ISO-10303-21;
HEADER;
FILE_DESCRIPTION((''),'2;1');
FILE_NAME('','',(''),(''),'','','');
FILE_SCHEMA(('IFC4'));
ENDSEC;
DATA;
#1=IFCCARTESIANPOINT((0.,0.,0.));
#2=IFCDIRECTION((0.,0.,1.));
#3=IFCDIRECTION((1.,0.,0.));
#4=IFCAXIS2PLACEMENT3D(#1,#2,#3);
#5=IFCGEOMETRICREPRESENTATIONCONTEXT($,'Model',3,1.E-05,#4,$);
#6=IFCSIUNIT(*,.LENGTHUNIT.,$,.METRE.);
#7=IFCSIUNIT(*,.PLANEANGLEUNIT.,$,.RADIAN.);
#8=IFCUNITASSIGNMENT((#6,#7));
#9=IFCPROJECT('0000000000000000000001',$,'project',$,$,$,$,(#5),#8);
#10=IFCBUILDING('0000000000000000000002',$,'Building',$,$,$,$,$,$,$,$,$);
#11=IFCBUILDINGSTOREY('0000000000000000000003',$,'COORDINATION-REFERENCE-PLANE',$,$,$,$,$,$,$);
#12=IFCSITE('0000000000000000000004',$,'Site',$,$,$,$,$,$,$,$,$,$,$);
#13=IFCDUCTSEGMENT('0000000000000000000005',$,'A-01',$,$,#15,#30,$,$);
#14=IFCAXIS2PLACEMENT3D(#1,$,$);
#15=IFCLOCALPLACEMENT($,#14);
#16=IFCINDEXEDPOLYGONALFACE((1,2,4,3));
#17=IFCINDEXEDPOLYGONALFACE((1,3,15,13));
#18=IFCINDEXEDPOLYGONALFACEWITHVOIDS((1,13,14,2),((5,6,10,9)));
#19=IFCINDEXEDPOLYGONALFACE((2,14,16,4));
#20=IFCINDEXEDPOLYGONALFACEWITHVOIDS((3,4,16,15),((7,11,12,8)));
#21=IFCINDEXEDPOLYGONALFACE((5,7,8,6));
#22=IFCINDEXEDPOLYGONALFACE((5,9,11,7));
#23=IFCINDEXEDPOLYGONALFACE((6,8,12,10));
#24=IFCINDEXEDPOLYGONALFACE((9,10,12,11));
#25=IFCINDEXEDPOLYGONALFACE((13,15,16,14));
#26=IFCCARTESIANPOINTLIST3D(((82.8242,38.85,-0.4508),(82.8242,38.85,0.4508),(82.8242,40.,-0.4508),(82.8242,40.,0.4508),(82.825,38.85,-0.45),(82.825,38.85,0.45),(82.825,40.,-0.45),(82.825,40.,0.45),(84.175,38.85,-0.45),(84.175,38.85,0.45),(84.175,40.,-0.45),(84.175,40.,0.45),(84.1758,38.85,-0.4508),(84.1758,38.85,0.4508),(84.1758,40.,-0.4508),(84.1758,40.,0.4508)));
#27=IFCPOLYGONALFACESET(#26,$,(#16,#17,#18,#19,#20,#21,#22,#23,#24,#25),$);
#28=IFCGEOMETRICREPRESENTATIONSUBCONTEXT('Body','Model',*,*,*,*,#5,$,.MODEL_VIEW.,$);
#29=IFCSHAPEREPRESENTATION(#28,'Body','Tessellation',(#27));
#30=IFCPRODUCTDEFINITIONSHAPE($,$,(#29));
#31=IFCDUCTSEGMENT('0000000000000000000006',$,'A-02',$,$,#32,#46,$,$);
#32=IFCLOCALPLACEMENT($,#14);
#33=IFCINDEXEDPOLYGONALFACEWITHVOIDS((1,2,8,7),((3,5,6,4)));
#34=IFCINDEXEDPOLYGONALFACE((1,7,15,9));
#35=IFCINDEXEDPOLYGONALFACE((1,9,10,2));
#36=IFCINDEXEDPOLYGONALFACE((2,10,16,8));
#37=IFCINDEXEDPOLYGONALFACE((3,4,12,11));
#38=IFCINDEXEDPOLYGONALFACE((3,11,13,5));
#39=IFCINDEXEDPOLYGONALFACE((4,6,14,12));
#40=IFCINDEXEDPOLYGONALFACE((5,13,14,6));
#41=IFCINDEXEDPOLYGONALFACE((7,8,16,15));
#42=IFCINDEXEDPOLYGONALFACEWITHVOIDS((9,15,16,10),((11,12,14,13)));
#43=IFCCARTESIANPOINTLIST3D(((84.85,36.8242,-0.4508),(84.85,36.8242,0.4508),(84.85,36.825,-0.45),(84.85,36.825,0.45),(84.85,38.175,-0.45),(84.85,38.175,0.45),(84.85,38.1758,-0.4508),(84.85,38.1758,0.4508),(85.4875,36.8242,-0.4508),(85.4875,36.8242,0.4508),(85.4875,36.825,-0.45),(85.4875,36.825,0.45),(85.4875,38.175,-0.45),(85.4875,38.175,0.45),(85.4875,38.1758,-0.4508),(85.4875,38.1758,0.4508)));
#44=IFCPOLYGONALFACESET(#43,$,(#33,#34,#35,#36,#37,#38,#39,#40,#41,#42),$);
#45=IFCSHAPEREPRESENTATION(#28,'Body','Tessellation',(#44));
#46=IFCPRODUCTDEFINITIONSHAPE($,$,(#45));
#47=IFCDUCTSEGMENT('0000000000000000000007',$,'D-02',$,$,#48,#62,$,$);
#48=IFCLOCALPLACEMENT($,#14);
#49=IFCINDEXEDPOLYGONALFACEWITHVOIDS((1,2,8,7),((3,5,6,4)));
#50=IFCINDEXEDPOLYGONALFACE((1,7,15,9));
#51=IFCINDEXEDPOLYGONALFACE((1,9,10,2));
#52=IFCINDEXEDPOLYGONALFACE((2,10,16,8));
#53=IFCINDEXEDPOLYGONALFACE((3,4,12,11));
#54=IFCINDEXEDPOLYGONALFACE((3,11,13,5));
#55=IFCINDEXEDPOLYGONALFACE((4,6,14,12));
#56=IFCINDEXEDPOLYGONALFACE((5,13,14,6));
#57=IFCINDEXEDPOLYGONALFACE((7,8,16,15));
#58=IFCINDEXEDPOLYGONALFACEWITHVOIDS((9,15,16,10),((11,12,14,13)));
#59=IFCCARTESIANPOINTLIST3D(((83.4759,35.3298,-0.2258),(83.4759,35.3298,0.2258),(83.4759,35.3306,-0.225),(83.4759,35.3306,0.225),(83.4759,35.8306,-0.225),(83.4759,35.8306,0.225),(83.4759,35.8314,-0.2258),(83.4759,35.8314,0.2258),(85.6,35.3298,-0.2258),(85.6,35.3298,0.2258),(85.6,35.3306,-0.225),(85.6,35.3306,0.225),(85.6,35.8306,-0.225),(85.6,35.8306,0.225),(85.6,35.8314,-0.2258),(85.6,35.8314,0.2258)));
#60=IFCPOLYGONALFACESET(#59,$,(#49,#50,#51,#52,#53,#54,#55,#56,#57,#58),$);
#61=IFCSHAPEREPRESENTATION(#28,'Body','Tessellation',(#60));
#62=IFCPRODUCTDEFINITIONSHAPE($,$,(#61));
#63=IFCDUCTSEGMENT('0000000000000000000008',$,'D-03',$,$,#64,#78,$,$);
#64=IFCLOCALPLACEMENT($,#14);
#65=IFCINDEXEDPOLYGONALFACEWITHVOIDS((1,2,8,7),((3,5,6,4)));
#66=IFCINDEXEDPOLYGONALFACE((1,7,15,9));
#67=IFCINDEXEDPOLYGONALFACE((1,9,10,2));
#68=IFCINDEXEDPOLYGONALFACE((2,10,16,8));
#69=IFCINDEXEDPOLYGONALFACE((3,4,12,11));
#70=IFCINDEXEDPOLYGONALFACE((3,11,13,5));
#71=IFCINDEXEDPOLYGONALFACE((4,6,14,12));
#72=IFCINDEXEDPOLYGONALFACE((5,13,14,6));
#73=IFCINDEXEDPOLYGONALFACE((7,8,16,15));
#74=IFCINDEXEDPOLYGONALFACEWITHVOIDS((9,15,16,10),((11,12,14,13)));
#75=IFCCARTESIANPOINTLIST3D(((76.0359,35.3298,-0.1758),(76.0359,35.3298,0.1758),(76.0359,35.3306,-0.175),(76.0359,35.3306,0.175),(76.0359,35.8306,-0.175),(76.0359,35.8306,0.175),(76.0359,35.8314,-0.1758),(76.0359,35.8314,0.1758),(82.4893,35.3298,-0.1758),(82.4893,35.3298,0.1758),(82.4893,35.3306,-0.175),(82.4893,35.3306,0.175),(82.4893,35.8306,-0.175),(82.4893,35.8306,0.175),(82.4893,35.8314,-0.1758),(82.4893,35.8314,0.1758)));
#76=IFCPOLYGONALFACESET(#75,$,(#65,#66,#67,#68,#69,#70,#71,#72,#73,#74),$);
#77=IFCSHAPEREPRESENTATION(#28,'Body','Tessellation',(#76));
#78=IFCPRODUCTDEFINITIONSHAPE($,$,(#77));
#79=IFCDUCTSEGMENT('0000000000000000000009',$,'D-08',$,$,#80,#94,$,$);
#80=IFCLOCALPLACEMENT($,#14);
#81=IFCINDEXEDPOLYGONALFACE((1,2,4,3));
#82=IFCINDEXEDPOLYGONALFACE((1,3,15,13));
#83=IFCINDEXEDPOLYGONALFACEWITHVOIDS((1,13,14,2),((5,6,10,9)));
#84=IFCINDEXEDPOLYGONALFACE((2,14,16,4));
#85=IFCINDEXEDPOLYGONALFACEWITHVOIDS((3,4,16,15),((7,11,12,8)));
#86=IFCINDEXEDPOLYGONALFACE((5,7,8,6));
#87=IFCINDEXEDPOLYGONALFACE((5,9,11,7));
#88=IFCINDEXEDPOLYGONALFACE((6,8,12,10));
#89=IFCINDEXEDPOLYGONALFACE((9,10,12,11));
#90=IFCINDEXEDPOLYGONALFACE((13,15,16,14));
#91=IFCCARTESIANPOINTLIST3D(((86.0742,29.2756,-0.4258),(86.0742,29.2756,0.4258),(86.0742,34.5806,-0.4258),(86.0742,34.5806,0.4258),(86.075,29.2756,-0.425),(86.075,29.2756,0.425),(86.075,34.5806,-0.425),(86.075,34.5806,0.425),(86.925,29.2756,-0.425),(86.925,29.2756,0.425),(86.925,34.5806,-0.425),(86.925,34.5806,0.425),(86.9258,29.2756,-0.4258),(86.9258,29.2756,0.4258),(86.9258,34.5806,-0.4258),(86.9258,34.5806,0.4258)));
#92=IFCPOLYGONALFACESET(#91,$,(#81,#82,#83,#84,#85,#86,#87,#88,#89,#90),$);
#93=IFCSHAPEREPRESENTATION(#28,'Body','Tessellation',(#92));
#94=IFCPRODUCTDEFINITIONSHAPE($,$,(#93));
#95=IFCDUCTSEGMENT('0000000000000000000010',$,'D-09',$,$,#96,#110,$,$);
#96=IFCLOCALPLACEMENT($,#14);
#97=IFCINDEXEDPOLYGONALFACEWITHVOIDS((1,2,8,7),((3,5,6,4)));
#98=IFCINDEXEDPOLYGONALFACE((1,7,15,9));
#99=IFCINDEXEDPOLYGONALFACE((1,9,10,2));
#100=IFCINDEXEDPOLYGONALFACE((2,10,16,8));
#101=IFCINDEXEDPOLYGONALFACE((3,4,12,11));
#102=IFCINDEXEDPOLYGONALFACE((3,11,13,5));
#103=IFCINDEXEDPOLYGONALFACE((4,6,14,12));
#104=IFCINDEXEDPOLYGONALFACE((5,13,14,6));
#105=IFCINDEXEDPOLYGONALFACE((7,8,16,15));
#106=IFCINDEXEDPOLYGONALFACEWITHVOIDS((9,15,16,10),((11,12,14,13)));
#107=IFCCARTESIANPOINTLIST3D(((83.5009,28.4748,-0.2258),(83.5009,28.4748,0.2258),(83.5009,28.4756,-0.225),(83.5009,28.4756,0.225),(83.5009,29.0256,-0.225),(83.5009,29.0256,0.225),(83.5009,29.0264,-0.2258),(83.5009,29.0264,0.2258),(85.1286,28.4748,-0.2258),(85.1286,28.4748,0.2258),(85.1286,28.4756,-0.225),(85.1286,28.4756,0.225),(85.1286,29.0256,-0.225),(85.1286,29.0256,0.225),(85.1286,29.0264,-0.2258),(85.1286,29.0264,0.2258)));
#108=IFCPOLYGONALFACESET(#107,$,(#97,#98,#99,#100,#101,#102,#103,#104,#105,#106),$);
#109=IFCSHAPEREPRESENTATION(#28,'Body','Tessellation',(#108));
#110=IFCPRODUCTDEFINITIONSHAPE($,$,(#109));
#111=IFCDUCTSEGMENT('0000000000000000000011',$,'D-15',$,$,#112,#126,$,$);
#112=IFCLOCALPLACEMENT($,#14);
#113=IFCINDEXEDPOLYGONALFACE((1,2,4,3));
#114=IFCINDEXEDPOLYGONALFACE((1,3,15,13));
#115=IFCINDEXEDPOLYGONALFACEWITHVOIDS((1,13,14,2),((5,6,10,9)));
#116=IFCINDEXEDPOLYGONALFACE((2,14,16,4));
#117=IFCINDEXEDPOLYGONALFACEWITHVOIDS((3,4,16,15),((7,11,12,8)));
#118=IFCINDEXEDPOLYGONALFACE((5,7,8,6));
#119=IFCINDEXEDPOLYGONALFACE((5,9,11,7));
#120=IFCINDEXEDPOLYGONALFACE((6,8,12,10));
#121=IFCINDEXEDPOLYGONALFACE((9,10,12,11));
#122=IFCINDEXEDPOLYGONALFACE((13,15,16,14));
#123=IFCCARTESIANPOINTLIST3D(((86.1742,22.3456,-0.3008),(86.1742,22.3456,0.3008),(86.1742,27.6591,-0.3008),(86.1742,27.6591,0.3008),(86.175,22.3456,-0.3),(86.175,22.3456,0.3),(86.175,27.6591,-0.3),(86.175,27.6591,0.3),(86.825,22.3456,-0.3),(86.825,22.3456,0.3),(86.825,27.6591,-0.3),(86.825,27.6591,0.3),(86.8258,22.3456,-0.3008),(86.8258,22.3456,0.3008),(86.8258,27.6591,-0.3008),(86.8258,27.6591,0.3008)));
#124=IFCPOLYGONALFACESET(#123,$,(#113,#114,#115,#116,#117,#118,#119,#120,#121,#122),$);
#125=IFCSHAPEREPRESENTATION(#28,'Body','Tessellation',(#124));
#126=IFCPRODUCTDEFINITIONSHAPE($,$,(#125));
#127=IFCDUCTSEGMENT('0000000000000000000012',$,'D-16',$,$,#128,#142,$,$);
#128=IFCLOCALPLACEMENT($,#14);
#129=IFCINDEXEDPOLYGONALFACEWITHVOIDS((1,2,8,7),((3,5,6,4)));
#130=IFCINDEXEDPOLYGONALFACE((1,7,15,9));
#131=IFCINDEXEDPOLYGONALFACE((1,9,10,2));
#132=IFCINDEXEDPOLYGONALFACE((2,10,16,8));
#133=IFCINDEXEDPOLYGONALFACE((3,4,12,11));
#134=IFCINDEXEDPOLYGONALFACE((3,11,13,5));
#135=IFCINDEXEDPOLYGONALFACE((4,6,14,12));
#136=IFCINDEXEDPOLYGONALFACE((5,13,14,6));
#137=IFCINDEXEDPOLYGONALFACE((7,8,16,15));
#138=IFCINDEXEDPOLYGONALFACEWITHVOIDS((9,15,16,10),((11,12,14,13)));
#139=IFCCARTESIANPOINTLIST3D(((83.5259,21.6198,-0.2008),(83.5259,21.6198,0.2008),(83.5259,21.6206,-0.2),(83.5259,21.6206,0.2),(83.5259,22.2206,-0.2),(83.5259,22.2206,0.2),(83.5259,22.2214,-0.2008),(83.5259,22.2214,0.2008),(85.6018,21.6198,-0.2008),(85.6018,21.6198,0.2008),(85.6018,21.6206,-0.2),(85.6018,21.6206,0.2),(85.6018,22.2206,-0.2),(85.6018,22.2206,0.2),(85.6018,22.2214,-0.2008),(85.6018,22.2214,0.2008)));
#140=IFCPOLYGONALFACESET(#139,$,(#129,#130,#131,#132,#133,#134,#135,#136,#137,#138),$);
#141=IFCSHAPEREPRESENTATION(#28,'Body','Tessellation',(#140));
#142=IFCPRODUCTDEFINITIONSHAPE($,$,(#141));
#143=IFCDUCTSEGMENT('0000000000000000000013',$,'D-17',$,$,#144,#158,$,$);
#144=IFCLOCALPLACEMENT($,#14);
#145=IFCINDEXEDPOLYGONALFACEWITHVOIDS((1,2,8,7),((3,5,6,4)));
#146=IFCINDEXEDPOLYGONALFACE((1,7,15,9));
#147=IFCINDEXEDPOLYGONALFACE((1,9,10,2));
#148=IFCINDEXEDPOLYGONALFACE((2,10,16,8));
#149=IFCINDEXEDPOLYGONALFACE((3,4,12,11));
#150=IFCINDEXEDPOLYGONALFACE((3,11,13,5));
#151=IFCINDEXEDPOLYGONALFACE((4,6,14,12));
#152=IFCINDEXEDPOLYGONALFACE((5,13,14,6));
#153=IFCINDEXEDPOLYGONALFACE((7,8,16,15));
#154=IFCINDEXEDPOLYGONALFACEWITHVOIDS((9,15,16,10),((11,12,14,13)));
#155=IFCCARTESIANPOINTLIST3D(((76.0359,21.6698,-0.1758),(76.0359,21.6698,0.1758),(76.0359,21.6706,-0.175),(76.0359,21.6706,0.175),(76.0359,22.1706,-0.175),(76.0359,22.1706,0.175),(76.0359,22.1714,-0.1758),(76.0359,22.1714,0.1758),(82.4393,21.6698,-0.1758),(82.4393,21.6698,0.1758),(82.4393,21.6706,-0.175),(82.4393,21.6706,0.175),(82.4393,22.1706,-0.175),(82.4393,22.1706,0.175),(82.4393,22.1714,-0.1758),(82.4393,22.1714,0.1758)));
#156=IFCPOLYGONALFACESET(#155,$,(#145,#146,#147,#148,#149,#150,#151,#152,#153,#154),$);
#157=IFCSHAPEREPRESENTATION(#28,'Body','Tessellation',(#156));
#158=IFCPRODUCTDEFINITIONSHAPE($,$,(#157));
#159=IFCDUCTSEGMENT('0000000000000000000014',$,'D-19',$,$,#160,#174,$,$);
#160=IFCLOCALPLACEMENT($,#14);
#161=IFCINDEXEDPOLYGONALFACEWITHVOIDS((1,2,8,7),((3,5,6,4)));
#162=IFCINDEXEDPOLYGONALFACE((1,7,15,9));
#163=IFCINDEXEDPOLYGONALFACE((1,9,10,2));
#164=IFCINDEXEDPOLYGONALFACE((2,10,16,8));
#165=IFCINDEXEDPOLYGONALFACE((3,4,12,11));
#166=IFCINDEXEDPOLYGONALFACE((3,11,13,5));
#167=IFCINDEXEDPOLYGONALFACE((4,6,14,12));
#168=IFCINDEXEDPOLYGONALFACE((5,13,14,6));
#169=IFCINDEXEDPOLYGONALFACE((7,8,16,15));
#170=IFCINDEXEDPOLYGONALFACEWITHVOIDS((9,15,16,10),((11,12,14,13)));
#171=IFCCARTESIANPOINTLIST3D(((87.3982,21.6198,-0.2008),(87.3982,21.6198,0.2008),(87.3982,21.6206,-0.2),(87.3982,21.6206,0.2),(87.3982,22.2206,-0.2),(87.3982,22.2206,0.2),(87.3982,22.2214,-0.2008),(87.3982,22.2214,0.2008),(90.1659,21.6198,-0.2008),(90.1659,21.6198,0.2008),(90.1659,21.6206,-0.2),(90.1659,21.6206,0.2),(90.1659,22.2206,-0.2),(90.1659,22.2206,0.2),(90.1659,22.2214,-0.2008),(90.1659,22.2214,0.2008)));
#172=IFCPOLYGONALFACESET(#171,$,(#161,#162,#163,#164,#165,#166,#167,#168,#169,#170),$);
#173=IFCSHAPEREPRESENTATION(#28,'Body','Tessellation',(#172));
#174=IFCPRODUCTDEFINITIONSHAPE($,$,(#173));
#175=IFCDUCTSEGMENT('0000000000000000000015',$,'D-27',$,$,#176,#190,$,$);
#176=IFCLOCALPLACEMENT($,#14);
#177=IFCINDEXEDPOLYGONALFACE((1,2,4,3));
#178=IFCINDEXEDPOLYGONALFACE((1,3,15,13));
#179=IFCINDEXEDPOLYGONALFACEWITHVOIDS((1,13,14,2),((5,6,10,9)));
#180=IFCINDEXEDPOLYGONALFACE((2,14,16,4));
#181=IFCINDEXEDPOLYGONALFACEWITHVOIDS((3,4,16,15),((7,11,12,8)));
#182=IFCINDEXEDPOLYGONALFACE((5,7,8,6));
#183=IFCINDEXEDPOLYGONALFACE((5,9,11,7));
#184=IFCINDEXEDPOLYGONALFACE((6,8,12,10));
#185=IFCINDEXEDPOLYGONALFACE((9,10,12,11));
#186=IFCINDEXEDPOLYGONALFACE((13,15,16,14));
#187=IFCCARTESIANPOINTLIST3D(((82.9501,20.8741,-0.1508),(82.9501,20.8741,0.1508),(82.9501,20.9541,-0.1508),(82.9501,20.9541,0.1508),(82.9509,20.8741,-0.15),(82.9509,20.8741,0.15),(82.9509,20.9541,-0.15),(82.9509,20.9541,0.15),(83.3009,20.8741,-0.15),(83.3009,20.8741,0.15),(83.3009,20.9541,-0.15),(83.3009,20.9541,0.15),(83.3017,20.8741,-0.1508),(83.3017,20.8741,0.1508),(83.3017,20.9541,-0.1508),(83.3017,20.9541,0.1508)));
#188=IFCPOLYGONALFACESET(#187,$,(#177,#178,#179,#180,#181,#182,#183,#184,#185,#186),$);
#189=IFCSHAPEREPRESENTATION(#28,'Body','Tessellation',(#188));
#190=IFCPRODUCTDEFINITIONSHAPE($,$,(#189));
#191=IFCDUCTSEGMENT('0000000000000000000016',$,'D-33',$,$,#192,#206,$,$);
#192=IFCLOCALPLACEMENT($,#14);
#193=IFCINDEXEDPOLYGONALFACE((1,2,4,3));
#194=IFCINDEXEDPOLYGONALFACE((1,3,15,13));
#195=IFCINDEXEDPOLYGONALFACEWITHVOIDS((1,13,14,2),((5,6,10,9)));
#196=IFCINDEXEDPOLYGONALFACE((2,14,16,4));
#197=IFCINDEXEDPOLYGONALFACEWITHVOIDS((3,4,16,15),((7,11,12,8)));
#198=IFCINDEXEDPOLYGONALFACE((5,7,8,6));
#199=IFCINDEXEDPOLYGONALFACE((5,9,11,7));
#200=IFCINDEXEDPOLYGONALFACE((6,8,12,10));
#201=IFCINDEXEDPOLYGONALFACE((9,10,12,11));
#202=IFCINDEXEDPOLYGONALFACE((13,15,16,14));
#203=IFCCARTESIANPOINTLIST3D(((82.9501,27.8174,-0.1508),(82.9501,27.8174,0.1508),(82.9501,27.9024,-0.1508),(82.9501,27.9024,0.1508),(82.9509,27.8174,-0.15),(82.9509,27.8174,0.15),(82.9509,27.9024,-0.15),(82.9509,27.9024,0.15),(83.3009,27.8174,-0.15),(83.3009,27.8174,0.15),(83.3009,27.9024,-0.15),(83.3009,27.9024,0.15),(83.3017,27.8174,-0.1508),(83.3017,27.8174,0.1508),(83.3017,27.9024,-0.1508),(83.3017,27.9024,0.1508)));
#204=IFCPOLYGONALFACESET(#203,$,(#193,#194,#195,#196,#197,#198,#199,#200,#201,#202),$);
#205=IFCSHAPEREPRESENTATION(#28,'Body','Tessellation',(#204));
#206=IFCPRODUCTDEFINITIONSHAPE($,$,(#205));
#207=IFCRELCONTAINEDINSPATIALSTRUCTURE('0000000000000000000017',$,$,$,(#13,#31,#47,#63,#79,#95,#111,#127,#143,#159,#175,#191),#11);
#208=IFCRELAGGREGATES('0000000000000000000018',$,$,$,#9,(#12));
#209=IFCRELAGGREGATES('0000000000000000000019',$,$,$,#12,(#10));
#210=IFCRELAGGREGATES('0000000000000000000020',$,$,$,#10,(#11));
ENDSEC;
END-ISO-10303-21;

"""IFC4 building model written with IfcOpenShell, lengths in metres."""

from ifc_helpers import new_model, si_unit, frame, origin, origin_with_axes, place, context, subcontext, project, spatial, hollow_rectangle, extrude, element, save


model = new_model("IFC4")

# Units and contexts
model_context = context("Model", 3, precision=1e-05, world=origin_with_axes())
body_context_1 = subcontext(model_context, "Body", "Model", "MODEL_VIEW")
ifc_project = project(units=[si_unit("LENGTHUNIT", "METRE"), si_unit("PLANEANGLEUNIT", "RADIAN")], contexts=[model_context])

# Site, building, storey
site = spatial("IfcSite", under=ifc_project, Name="Site")
building = spatial("IfcBuilding", under=site, Name="Building")
storey = spatial("IfcBuildingStorey", under=building, Name="COORDINATION-REFERENCE-PLANE")

# Duct segments
duct_segment_1_placement = place(None, frame((83.5, 38.85, 0.0), z_axis=(0.0, 1.0, 0.0), x_axis=(1.0, 0.0, 0.0)))
element("IfcDuctSegment", 1, at=duct_segment_1_placement, inside=storey, Name="A-01", context=body_context_1, shape_type="SweptSolid", body=[
    extrude(hollow_rectangle(XDim=1.3516, YDim=0.9016, WallThickness=0.0008), origin(), (0.0, 0.0, 1.0), 1.15),
])
duct_segment_2_placement = place(None, frame((84.85, 37.5, 0.0), z_axis=(1.0, 0.0, 0.0), x_axis=(0.0, 1.0, 0.0)))
element("IfcDuctSegment", 2, at=duct_segment_2_placement, inside=storey, Name="A-02", context=body_context_1, shape_type="SweptSolid", body=[
    extrude(hollow_rectangle(XDim=1.3516, YDim=0.9016, WallThickness=0.0008), origin(), (0.0, 0.0, 1.0), 0.6375),
])
duct_segment_3_placement = place(None, frame((83.4759, 35.5806, 0.0), z_axis=(1.0, 0.0, 0.0), x_axis=(0.0, 1.0, 0.0)))
element("IfcDuctSegment", 3, at=duct_segment_3_placement, inside=storey, Name="D-02", context=body_context_1, shape_type="SweptSolid", body=[
    extrude(hollow_rectangle(XDim=0.5016, YDim=0.4516, WallThickness=0.0008), origin(), (0.0, 0.0, 1.0), 2.1241),
])
duct_segment_4_placement = place(None, frame((76.0359, 35.5806, 0.0), z_axis=(1.0, 0.0, 0.0), x_axis=(0.0, 1.0, 0.0)))
element("IfcDuctSegment", 4, at=duct_segment_4_placement, inside=storey, Name="D-03", context=body_context_1, shape_type="SweptSolid", body=[
    extrude(hollow_rectangle(XDim=0.5016, YDim=0.3516, WallThickness=0.0008), origin(), (0.0, 0.0, 1.0), 6.4534),
])
duct_segment_5_placement = place(None, frame((86.5, 29.2756, 0.0), z_axis=(0.0, 1.0, 0.0), x_axis=(1.0, 0.0, 0.0)))
element("IfcDuctSegment", 5, at=duct_segment_5_placement, inside=storey, Name="D-08", context=body_context_1, shape_type="SweptSolid", body=[
    extrude(hollow_rectangle(XDim=0.8516, YDim=0.8516, WallThickness=0.0008), origin(), (0.0, 0.0, 1.0), 5.305),
])
duct_segment_6_placement = place(None, frame((83.5009, 28.7506, 0.0), z_axis=(1.0, 0.0, 0.0), x_axis=(0.0, 1.0, 0.0)))
element("IfcDuctSegment", 6, at=duct_segment_6_placement, inside=storey, Name="D-09", context=body_context_1, shape_type="SweptSolid", body=[
    extrude(hollow_rectangle(XDim=0.5516, YDim=0.4516, WallThickness=0.0008), origin(), (0.0, 0.0, 1.0), 1.6277),
])
duct_segment_7_placement = place(None, frame((86.5, 22.3456, 0.0), z_axis=(0.0, 1.0, 0.0), x_axis=(1.0, 0.0, 0.0)))
element("IfcDuctSegment", 7, at=duct_segment_7_placement, inside=storey, Name="D-15", context=body_context_1, shape_type="SweptSolid", body=[
    extrude(hollow_rectangle(XDim=0.6516, YDim=0.6016, WallThickness=0.0008), origin(), (0.0, 0.0, 1.0), 5.3135),
])
duct_segment_8_placement = place(None, frame((83.5259, 21.9206, 0.0), z_axis=(1.0, 0.0, 0.0), x_axis=(0.0, 1.0, 0.0)))
element("IfcDuctSegment", 8, at=duct_segment_8_placement, inside=storey, Name="D-16", context=body_context_1, shape_type="SweptSolid", body=[
    extrude(hollow_rectangle(XDim=0.6016, YDim=0.4016, WallThickness=0.0008), origin(), (0.0, 0.0, 1.0), 2.0759),
])
duct_segment_9_placement = place(None, frame((76.0359, 21.9206, 0.0), z_axis=(1.0, 0.0, 0.0), x_axis=(0.0, 1.0, 0.0)))
element("IfcDuctSegment", 9, at=duct_segment_9_placement, inside=storey, Name="D-17", context=body_context_1, shape_type="SweptSolid", body=[
    extrude(hollow_rectangle(XDim=0.5016, YDim=0.3516, WallThickness=0.0008), origin(), (0.0, 0.0, 1.0), 6.4034),
])
duct_segment_10_placement = place(None, frame((87.3982, 21.9206, 0.0), z_axis=(1.0, 0.0, 0.0), x_axis=(0.0, 1.0, 0.0)))
element("IfcDuctSegment", 10, at=duct_segment_10_placement, inside=storey, Name="D-19", context=body_context_1, shape_type="SweptSolid", body=[
    extrude(hollow_rectangle(XDim=0.6016, YDim=0.4016, WallThickness=0.0008), origin(), (0.0, 0.0, 1.0), 2.7677),
])
duct_segment_11_placement = place(None, frame((83.1259, 20.8741, 0.0), z_axis=(0.0, 1.0, 0.0), x_axis=(1.0, 0.0, 0.0)))
element("IfcDuctSegment", 11, at=duct_segment_11_placement, inside=storey, Name="D-27", context=body_context_1, shape_type="SweptSolid", body=[
    extrude(hollow_rectangle(XDim=0.3516, YDim=0.3016, WallThickness=0.0008), origin(), (0.0, 0.0, 1.0), 0.08),
])
duct_segment_12_placement = place(None, frame((83.1259, 27.8174, 0.0), z_axis=(0.0, 1.0, 0.0), x_axis=(1.0, 0.0, 0.0)))
element("IfcDuctSegment", 12, at=duct_segment_12_placement, inside=storey, Name="D-33", context=body_context_1, shape_type="SweptSolid", body=[
    extrude(hollow_rectangle(XDim=0.3516, YDim=0.3016, WallThickness=0.0008), origin(), (0.0, 0.0, 1.0), 0.085),
])

save(model, "model.ifc")
